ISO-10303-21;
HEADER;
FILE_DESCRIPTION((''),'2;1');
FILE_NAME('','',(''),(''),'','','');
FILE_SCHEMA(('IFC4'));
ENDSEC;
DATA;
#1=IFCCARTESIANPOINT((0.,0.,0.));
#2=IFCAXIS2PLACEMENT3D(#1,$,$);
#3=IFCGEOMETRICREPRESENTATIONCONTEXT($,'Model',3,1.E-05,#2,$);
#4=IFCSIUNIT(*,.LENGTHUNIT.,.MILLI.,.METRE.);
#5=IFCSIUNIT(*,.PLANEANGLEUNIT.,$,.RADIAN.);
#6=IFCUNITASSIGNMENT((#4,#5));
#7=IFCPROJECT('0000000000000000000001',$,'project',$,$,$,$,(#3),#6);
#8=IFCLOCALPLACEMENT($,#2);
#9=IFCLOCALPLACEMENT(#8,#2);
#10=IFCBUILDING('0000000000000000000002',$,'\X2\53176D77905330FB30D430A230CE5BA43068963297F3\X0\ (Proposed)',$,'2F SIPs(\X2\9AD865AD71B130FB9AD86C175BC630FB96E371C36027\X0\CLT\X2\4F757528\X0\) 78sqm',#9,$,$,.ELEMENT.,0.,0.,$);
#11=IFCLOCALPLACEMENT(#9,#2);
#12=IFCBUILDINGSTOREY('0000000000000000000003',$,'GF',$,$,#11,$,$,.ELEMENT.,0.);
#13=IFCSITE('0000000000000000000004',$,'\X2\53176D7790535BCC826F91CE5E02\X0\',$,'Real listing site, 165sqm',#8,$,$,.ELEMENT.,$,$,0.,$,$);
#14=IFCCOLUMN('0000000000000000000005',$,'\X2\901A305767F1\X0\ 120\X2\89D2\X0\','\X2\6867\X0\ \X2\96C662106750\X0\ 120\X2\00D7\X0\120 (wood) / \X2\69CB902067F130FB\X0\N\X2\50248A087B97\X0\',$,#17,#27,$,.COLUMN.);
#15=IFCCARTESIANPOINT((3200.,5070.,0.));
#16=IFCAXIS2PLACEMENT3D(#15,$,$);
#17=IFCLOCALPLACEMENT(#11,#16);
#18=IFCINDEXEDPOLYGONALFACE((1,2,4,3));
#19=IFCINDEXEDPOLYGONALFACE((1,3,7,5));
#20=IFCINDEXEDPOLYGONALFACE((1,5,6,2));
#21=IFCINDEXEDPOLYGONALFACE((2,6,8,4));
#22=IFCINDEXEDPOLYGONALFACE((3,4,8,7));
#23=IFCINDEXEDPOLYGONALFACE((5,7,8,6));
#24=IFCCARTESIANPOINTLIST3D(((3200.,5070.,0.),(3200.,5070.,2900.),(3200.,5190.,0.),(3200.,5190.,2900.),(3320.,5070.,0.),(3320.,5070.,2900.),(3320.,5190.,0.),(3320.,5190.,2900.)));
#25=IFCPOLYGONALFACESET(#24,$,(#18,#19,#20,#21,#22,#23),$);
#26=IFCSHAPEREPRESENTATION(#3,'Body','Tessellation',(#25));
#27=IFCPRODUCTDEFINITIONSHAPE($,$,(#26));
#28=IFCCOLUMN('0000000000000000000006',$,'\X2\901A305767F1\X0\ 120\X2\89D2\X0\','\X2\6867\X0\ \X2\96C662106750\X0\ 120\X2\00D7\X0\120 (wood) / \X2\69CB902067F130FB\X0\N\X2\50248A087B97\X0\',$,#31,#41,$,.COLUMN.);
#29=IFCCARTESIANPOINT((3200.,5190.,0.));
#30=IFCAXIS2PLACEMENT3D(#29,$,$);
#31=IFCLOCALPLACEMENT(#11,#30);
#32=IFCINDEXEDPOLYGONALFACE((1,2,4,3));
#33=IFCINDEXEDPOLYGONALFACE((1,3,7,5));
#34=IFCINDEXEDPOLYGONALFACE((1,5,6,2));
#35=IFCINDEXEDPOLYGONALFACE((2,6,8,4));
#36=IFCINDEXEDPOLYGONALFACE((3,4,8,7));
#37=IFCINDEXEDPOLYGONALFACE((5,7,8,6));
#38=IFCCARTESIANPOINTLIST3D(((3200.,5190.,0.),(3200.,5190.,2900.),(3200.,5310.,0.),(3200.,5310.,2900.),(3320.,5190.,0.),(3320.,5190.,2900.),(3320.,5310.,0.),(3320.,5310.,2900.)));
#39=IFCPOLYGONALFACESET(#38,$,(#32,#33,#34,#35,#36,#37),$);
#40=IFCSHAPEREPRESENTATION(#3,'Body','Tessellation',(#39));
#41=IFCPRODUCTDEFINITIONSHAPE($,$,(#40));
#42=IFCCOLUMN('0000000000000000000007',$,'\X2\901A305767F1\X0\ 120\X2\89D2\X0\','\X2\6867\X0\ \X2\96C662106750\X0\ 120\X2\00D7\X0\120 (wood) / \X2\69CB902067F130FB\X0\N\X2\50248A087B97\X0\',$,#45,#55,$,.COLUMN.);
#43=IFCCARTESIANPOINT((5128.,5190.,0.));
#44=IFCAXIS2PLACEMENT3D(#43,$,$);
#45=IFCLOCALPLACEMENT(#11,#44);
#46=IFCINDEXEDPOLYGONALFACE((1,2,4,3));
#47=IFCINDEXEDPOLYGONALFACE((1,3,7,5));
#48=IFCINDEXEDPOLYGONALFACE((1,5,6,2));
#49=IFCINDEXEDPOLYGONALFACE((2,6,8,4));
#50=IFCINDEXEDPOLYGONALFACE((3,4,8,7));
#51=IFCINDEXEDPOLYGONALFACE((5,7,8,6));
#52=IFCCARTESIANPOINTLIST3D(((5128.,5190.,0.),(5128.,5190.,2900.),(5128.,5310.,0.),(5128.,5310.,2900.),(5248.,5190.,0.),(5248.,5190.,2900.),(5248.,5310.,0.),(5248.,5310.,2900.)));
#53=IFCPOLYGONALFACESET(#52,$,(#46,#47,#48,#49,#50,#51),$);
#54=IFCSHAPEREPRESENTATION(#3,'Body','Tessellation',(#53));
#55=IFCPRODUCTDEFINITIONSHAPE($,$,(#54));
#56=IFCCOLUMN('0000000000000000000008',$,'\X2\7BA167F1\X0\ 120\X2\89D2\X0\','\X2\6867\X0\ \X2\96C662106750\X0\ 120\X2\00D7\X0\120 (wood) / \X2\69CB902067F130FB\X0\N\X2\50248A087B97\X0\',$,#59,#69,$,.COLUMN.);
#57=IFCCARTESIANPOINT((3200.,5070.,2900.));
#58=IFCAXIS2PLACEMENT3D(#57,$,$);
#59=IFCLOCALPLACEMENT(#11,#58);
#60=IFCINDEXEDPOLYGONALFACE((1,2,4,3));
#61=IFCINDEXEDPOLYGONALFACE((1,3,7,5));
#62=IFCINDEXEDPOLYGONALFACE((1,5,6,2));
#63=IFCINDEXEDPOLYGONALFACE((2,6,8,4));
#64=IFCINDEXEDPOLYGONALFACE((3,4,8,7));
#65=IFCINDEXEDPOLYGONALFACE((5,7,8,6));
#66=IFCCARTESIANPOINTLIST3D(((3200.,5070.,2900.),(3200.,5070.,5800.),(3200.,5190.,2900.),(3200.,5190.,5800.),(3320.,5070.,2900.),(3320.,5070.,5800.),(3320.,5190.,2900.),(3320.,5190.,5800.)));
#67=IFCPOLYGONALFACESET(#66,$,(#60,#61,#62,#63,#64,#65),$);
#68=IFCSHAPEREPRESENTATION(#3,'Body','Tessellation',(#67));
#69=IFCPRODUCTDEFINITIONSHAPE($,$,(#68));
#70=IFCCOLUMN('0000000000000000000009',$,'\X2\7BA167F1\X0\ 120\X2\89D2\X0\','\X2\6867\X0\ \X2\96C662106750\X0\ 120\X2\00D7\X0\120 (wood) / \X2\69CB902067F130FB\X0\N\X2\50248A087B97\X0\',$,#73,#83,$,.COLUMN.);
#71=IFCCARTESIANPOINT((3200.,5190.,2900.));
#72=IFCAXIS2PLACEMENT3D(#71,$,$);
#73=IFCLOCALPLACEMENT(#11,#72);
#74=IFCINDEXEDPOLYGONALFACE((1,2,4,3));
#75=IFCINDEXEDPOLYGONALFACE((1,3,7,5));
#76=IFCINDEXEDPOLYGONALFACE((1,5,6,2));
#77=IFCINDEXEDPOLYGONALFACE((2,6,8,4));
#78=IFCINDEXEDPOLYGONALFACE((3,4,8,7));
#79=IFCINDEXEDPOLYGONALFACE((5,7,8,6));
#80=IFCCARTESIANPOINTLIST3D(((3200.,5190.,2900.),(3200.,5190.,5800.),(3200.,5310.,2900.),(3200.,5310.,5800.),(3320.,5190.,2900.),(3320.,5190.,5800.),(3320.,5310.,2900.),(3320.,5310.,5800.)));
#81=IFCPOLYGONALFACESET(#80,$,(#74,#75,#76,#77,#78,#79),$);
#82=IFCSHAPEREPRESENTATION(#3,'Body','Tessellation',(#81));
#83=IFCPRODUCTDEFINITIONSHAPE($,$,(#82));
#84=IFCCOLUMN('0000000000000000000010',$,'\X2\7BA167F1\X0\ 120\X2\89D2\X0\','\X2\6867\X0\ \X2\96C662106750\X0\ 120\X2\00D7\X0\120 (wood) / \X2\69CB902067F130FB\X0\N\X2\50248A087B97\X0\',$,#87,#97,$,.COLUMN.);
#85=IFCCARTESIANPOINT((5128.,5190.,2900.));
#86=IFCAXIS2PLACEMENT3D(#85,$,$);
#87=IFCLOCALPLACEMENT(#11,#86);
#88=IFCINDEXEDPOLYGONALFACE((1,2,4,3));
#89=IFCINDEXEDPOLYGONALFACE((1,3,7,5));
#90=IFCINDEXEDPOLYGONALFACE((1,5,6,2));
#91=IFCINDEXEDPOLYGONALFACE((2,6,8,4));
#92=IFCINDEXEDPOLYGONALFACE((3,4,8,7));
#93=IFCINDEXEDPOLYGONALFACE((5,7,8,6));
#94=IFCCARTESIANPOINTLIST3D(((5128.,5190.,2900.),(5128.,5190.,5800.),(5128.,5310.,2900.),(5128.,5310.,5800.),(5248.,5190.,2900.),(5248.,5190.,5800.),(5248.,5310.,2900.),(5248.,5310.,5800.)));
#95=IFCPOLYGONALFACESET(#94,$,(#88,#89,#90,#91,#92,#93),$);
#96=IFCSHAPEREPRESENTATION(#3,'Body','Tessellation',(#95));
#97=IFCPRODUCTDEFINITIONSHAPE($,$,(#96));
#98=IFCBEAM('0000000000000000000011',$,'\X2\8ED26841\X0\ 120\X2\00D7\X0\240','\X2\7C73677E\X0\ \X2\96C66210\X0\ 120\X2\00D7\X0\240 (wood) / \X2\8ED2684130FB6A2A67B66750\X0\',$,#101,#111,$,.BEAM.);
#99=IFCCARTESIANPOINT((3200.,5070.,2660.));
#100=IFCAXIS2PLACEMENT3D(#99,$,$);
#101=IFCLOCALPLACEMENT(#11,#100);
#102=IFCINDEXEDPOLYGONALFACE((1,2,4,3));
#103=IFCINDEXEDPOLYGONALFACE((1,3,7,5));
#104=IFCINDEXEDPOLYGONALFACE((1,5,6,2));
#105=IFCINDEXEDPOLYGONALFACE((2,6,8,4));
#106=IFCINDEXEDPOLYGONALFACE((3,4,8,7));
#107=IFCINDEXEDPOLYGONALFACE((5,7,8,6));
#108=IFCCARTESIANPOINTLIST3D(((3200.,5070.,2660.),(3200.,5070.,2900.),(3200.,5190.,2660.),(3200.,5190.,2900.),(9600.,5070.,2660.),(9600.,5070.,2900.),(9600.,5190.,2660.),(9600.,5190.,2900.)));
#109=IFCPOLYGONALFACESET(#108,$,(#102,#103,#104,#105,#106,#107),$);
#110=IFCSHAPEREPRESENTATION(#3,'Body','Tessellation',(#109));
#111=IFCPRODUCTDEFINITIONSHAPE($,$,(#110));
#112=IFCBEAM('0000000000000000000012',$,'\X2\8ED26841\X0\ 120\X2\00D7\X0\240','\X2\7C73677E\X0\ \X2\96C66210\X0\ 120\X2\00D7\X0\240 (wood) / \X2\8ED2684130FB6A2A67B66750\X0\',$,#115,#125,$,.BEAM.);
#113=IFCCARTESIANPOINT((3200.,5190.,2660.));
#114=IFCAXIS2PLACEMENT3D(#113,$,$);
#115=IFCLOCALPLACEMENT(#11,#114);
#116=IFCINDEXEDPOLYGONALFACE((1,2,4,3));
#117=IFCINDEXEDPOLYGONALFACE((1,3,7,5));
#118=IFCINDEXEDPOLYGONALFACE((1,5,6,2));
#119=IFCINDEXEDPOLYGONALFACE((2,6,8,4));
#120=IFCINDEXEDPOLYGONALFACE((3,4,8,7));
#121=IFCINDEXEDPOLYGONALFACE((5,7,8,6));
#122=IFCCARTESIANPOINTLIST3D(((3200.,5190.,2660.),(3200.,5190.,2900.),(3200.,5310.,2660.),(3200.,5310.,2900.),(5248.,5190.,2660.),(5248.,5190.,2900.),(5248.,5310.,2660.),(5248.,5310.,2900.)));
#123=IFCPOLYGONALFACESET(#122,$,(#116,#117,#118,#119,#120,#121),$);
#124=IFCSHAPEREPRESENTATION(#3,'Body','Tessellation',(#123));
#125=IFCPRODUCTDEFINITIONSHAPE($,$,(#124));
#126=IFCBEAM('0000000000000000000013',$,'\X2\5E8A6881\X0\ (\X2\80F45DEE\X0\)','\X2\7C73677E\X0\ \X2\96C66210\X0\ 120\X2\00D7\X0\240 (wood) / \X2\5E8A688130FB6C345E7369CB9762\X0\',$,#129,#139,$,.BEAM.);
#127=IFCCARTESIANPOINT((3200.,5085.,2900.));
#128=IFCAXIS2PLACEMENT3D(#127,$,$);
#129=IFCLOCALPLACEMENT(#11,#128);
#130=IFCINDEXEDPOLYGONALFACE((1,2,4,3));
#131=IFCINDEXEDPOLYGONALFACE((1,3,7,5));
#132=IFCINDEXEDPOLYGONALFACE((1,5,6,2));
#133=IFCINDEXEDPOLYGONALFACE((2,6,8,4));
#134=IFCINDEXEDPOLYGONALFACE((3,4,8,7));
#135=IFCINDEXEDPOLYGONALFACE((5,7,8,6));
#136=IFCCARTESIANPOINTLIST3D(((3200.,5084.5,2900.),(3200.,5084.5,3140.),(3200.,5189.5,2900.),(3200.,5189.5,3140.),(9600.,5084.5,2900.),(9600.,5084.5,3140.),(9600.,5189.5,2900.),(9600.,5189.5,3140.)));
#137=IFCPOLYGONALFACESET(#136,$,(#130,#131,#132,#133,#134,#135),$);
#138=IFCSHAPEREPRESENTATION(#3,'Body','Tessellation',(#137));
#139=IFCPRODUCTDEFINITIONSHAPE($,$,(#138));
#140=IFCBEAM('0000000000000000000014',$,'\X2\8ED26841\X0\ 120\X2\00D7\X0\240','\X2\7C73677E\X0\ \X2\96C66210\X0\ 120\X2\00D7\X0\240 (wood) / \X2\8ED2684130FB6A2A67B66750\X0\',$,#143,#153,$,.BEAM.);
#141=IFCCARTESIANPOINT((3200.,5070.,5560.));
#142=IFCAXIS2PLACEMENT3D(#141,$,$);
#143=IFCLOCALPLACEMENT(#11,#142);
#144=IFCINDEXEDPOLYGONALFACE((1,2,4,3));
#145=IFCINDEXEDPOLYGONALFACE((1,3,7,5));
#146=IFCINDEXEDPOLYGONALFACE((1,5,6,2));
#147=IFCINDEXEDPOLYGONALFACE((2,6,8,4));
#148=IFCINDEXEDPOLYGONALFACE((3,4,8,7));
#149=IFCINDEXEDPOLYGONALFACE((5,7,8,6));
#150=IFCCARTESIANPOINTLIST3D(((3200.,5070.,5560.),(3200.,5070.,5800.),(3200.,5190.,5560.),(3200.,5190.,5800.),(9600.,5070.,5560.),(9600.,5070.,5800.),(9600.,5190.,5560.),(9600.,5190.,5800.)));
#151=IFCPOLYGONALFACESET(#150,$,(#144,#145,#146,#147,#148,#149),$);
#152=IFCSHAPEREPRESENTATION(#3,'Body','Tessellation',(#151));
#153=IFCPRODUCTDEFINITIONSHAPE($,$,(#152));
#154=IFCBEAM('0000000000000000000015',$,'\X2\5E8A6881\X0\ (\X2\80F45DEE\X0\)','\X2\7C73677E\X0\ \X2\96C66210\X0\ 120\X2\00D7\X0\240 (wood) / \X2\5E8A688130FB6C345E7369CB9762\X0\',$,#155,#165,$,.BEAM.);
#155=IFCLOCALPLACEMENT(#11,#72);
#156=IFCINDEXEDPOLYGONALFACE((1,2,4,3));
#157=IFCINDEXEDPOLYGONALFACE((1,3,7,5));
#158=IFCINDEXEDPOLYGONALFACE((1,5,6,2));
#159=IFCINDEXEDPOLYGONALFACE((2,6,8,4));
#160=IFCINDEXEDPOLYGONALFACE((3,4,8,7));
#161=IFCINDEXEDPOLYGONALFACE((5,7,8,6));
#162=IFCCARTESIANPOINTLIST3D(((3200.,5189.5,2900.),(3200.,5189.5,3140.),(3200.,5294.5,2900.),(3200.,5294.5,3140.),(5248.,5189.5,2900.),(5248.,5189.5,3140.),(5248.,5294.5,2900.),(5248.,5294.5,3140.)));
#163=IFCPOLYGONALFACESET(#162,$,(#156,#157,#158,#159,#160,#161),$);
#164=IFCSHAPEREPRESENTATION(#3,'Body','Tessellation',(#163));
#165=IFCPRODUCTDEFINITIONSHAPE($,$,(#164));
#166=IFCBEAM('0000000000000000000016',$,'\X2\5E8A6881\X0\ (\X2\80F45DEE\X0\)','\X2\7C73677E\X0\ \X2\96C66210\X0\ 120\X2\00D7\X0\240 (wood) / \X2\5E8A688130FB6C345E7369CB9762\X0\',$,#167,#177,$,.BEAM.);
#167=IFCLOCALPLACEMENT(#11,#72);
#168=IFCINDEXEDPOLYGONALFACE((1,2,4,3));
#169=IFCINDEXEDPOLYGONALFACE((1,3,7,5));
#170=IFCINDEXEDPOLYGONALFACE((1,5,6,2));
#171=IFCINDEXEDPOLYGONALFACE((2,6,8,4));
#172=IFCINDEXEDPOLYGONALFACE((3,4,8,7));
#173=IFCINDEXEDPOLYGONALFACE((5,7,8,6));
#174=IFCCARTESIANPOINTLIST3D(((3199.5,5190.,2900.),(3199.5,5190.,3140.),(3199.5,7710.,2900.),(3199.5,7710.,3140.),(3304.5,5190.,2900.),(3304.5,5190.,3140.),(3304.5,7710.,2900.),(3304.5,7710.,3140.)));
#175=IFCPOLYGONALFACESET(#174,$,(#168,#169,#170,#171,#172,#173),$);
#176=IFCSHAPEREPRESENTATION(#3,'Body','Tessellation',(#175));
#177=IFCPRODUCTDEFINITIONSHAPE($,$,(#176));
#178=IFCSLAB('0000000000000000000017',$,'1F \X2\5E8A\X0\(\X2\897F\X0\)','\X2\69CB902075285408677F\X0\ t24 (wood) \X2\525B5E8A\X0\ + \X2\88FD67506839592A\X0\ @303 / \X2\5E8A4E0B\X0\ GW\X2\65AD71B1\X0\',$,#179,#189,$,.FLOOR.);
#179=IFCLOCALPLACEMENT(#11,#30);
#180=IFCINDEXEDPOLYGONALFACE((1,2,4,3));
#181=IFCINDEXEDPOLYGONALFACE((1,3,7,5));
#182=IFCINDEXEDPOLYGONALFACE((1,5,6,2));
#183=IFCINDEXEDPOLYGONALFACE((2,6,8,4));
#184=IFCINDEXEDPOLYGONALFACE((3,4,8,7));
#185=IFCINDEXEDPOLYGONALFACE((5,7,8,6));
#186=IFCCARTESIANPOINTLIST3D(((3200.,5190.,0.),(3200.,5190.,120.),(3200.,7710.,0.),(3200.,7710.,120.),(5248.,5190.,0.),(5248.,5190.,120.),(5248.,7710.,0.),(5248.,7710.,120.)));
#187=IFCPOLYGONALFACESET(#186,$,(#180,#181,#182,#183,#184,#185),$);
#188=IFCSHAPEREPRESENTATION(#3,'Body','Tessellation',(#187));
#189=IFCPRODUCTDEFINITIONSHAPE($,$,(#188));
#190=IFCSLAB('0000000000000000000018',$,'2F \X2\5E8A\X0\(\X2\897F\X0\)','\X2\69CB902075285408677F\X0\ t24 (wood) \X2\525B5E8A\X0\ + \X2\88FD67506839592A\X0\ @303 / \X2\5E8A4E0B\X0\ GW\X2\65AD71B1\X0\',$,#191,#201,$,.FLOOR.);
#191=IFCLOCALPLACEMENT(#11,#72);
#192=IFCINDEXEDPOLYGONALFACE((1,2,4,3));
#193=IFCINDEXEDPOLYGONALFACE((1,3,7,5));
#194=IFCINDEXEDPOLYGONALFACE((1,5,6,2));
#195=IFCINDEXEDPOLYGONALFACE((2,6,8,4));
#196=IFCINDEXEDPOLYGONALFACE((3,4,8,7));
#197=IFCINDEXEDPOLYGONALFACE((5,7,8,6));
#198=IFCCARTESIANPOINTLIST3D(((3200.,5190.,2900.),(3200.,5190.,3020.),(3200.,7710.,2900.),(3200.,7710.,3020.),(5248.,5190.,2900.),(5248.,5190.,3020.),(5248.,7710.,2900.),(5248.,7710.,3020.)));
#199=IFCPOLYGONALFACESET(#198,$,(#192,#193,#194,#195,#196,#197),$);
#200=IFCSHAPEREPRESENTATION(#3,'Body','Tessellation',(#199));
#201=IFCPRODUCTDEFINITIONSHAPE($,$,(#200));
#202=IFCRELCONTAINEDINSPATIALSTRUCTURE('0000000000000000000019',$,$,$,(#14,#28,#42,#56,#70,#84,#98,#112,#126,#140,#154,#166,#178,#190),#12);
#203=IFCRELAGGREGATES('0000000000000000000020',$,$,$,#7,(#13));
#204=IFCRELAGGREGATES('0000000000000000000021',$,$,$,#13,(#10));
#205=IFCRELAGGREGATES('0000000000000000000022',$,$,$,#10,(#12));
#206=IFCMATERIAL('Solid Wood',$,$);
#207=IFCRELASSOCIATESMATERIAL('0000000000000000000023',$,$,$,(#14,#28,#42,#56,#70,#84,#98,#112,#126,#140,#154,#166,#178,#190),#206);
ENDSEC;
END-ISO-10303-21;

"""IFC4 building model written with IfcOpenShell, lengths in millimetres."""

from ifc_helpers import new_model, si_unit, frame, frame_2d, origin, place, context, project, spatial, rectangle, extrude, material, element, save


model = new_model("IFC4")

# Units and contexts
model_context = context("Model", 3, precision=1e-05, world=origin())
ifc_project = project(units=[si_unit("LENGTHUNIT", "METRE", prefix="MILLI"), si_unit("PLANEANGLEUNIT", "RADIAN")], contexts=[model_context])

# Site, building, storey
site_placement = place(None, origin())
site = spatial("IfcSite", under=ifc_project, at=site_placement, Name="北海道富良野市", ObjectType="Real listing site, 165sqm", CompositionType="ELEMENT", RefElevation=0.0)
building_placement = place(site_placement, origin())
building = spatial("IfcBuilding", under=site, at=building_placement, Name="北海道・ピアノ室と防音 (Proposed)", ObjectType="2F SIPs(高断熱・高気密・難燃性CLT併用) 78sqm", CompositionType="ELEMENT", ElevationOfRefHeight=0.0, ElevationOfTerrain=0.0)
storey_placement = place(building_placement, origin())
storey = spatial("IfcBuildingStorey", under=building, at=storey_placement, Name="GF", CompositionType="ELEMENT", Elevation=0.0)

# Columns
ifc_material_1 = material(Name="Solid Wood")
column_1_placement = place(storey_placement, frame((3200.0, 5070.0, 0.0)))
element("IfcColumn", 1, at=column_1_placement, inside=storey, material=ifc_material_1, Name="通し柱 120角", Description="桧 集成材 120×120 (wood) / 構造柱・N値計算", PredefinedType="COLUMN", context=model_context, shape_type="SweptSolid", body=[
    extrude(rectangle(XDim=120.0, YDim=120.0, at=frame_2d((60.0, 60.0))), frame((3200.0, 5070.0, 0.0)), (0.0, 0.0, 1.0), 2900.0),
])
column_2_placement = place(storey_placement, frame((3200.0, 5190.0, 0.0)))
element("IfcColumn", 2, at=column_2_placement, inside=storey, material=ifc_material_1, Name="通し柱 120角", Description="桧 集成材 120×120 (wood) / 構造柱・N値計算", PredefinedType="COLUMN", context=model_context, shape_type="SweptSolid", body=[
    extrude(rectangle(XDim=120.0, YDim=120.0, at=frame_2d((60.0, 60.0))), frame((3200.0, 5190.0, 0.0)), (0.0, 0.0, 1.0), 2900.0),
])
column_3_placement = place(storey_placement, frame((5128.0, 5190.0, 0.0)))
element("IfcColumn", 3, at=column_3_placement, inside=storey, material=ifc_material_1, Name="通し柱 120角", Description="桧 集成材 120×120 (wood) / 構造柱・N値計算", PredefinedType="COLUMN", context=model_context, shape_type="SweptSolid", body=[
    extrude(rectangle(XDim=120.0, YDim=120.0, at=frame_2d((60.0, 60.0))), frame((5128.0, 5190.0, 0.0)), (0.0, 0.0, 1.0), 2900.0),
])
column_4_placement = place(storey_placement, frame((3200.0, 5070.0, 2900.0)))
element("IfcColumn", 4, at=column_4_placement, inside=storey, material=ifc_material_1, Name="管柱 120角", Description="桧 集成材 120×120 (wood) / 構造柱・N値計算", PredefinedType="COLUMN", context=model_context, shape_type="SweptSolid", body=[
    extrude(rectangle(XDim=120.0, YDim=120.0, at=frame_2d((60.0, 60.0))), frame((3200.0, 5070.0, 2900.0)), (0.0, 0.0, 1.0), 2900.0),
])
column_5_placement = place(storey_placement, frame((3200.0, 5190.0, 2900.0)))
element("IfcColumn", 5, at=column_5_placement, inside=storey, material=ifc_material_1, Name="管柱 120角", Description="桧 集成材 120×120 (wood) / 構造柱・N値計算", PredefinedType="COLUMN", context=model_context, shape_type="SweptSolid", body=[
    extrude(rectangle(XDim=120.0, YDim=120.0, at=frame_2d((60.0, 60.0))), frame((3200.0, 5190.0, 2900.0)), (0.0, 0.0, 1.0), 2900.0),
])
column_6_placement = place(storey_placement, frame((5128.0, 5190.0, 2900.0)))
element("IfcColumn", 6, at=column_6_placement, inside=storey, material=ifc_material_1, Name="管柱 120角", Description="桧 集成材 120×120 (wood) / 構造柱・N値計算", PredefinedType="COLUMN", context=model_context, shape_type="SweptSolid", body=[
    extrude(rectangle(XDim=120.0, YDim=120.0, at=frame_2d((60.0, 60.0))), frame((5128.0, 5190.0, 2900.0)), (0.0, 0.0, 1.0), 2900.0),
])

# Beams
beam_1_placement = place(storey_placement, frame((3200.0, 5070.0, 2660.0)))
element("IfcBeam", 7, at=beam_1_placement, inside=storey, material=ifc_material_1, Name="軒桁 120×240", Description="米松 集成 120×240 (wood) / 軒桁・横架材", PredefinedType="BEAM", context=model_context, shape_type="SweptSolid", body=[
    extrude(rectangle(XDim=6400.0, YDim=120.0, at=frame_2d((3200.0, 60.0))), frame((3200.0, 5070.0, 2660.0)), (0.0, 0.0, 1.0), 240.0),
])
beam_2_placement = place(storey_placement, frame((3200.0, 5190.0, 2660.0)))
element("IfcBeam", 8, at=beam_2_placement, inside=storey, material=ifc_material_1, Name="軒桁 120×240", Description="米松 集成 120×240 (wood) / 軒桁・横架材", PredefinedType="BEAM", context=model_context, shape_type="SweptSolid", body=[
    extrude(rectangle(XDim=2048.0, YDim=120.0, at=frame_2d((1024.0, 60.0))), frame((3200.0, 5190.0, 2660.0)), (0.0, 0.0, 1.0), 240.0),
])
beam_3_placement = place(storey_placement, frame((3200.0, 5085.0, 2900.0)))
element("IfcBeam", 9, at=beam_3_placement, inside=storey, material=ifc_material_1, Name="床梁 (胴差)", Description="米松 集成 120×240 (wood) / 床梁・水平構面", PredefinedType="BEAM", context=model_context, shape_type="SweptSolid", body=[
    extrude(rectangle(XDim=6400.0, YDim=105.0, at=frame_2d((3200.0, 52.0))), frame((3200.0, 5085.0, 2900.0)), (0.0, 0.0, 1.0), 240.0),
])
beam_4_placement = place(storey_placement, frame((3200.0, 5070.0, 5560.0)))
element("IfcBeam", 10, at=beam_4_placement, inside=storey, material=ifc_material_1, Name="軒桁 120×240", Description="米松 集成 120×240 (wood) / 軒桁・横架材", PredefinedType="BEAM", context=model_context, shape_type="SweptSolid", body=[
    extrude(rectangle(XDim=6400.0, YDim=120.0, at=frame_2d((3200.0, 60.0))), frame((3200.0, 5070.0, 5560.0)), (0.0, 0.0, 1.0), 240.0),
])
beam_5_placement = place(storey_placement, frame((3200.0, 5190.0, 2900.0)))
element("IfcBeam", 11, at=beam_5_placement, inside=storey, material=ifc_material_1, Name="床梁 (胴差)", Description="米松 集成 120×240 (wood) / 床梁・水平構面", PredefinedType="BEAM", context=model_context, shape_type="SweptSolid", body=[
    extrude(rectangle(XDim=2048.0, YDim=105.0, at=frame_2d((1024.0, 52.0))), frame((3200.0, 5190.0, 2900.0)), (0.0, 0.0, 1.0), 240.0),
])
beam_6_placement = place(storey_placement, frame((3200.0, 5190.0, 2900.0)))
element("IfcBeam", 12, at=beam_6_placement, inside=storey, material=ifc_material_1, Name="床梁 (胴差)", Description="米松 集成 120×240 (wood) / 床梁・水平構面", PredefinedType="BEAM", context=model_context, shape_type="SweptSolid", body=[
    extrude(rectangle(XDim=105.0, YDim=2520.0, at=frame_2d((52.0, 1260.0))), frame((3200.0, 5190.0, 2900.0)), (0.0, 0.0, 1.0), 240.0),
])

# Slabs
slab_1_placement = place(storey_placement, frame((3200.0, 5190.0, 0.0)))
element("IfcSlab", 13, at=slab_1_placement, inside=storey, material=ifc_material_1, Name="1F 床(西)", Description="構造用合板 t24 (wood) 剛床 + 製材根太 @303 / 床下 GW断熱", PredefinedType="FLOOR", context=model_context, shape_type="SweptSolid", body=[
    extrude(rectangle(XDim=2048.0, YDim=2520.0, at=frame_2d((1024.0, 1260.0))), frame((3200.0, 5190.0, 0.0)), (0.0, 0.0, 1.0), 120.0),
])
slab_2_placement = place(storey_placement, frame((3200.0, 5190.0, 2900.0)))
element("IfcSlab", 14, at=slab_2_placement, inside=storey, material=ifc_material_1, Name="2F 床(西)", Description="構造用合板 t24 (wood) 剛床 + 製材根太 @303 / 床下 GW断熱", PredefinedType="FLOOR", context=model_context, shape_type="SweptSolid", body=[
    extrude(rectangle(XDim=2048.0, YDim=2520.0, at=frame_2d((1024.0, 1260.0))), frame((3200.0, 5190.0, 2900.0)), (0.0, 0.0, 1.0), 120.0),
])

save(model, "model.ifc")
